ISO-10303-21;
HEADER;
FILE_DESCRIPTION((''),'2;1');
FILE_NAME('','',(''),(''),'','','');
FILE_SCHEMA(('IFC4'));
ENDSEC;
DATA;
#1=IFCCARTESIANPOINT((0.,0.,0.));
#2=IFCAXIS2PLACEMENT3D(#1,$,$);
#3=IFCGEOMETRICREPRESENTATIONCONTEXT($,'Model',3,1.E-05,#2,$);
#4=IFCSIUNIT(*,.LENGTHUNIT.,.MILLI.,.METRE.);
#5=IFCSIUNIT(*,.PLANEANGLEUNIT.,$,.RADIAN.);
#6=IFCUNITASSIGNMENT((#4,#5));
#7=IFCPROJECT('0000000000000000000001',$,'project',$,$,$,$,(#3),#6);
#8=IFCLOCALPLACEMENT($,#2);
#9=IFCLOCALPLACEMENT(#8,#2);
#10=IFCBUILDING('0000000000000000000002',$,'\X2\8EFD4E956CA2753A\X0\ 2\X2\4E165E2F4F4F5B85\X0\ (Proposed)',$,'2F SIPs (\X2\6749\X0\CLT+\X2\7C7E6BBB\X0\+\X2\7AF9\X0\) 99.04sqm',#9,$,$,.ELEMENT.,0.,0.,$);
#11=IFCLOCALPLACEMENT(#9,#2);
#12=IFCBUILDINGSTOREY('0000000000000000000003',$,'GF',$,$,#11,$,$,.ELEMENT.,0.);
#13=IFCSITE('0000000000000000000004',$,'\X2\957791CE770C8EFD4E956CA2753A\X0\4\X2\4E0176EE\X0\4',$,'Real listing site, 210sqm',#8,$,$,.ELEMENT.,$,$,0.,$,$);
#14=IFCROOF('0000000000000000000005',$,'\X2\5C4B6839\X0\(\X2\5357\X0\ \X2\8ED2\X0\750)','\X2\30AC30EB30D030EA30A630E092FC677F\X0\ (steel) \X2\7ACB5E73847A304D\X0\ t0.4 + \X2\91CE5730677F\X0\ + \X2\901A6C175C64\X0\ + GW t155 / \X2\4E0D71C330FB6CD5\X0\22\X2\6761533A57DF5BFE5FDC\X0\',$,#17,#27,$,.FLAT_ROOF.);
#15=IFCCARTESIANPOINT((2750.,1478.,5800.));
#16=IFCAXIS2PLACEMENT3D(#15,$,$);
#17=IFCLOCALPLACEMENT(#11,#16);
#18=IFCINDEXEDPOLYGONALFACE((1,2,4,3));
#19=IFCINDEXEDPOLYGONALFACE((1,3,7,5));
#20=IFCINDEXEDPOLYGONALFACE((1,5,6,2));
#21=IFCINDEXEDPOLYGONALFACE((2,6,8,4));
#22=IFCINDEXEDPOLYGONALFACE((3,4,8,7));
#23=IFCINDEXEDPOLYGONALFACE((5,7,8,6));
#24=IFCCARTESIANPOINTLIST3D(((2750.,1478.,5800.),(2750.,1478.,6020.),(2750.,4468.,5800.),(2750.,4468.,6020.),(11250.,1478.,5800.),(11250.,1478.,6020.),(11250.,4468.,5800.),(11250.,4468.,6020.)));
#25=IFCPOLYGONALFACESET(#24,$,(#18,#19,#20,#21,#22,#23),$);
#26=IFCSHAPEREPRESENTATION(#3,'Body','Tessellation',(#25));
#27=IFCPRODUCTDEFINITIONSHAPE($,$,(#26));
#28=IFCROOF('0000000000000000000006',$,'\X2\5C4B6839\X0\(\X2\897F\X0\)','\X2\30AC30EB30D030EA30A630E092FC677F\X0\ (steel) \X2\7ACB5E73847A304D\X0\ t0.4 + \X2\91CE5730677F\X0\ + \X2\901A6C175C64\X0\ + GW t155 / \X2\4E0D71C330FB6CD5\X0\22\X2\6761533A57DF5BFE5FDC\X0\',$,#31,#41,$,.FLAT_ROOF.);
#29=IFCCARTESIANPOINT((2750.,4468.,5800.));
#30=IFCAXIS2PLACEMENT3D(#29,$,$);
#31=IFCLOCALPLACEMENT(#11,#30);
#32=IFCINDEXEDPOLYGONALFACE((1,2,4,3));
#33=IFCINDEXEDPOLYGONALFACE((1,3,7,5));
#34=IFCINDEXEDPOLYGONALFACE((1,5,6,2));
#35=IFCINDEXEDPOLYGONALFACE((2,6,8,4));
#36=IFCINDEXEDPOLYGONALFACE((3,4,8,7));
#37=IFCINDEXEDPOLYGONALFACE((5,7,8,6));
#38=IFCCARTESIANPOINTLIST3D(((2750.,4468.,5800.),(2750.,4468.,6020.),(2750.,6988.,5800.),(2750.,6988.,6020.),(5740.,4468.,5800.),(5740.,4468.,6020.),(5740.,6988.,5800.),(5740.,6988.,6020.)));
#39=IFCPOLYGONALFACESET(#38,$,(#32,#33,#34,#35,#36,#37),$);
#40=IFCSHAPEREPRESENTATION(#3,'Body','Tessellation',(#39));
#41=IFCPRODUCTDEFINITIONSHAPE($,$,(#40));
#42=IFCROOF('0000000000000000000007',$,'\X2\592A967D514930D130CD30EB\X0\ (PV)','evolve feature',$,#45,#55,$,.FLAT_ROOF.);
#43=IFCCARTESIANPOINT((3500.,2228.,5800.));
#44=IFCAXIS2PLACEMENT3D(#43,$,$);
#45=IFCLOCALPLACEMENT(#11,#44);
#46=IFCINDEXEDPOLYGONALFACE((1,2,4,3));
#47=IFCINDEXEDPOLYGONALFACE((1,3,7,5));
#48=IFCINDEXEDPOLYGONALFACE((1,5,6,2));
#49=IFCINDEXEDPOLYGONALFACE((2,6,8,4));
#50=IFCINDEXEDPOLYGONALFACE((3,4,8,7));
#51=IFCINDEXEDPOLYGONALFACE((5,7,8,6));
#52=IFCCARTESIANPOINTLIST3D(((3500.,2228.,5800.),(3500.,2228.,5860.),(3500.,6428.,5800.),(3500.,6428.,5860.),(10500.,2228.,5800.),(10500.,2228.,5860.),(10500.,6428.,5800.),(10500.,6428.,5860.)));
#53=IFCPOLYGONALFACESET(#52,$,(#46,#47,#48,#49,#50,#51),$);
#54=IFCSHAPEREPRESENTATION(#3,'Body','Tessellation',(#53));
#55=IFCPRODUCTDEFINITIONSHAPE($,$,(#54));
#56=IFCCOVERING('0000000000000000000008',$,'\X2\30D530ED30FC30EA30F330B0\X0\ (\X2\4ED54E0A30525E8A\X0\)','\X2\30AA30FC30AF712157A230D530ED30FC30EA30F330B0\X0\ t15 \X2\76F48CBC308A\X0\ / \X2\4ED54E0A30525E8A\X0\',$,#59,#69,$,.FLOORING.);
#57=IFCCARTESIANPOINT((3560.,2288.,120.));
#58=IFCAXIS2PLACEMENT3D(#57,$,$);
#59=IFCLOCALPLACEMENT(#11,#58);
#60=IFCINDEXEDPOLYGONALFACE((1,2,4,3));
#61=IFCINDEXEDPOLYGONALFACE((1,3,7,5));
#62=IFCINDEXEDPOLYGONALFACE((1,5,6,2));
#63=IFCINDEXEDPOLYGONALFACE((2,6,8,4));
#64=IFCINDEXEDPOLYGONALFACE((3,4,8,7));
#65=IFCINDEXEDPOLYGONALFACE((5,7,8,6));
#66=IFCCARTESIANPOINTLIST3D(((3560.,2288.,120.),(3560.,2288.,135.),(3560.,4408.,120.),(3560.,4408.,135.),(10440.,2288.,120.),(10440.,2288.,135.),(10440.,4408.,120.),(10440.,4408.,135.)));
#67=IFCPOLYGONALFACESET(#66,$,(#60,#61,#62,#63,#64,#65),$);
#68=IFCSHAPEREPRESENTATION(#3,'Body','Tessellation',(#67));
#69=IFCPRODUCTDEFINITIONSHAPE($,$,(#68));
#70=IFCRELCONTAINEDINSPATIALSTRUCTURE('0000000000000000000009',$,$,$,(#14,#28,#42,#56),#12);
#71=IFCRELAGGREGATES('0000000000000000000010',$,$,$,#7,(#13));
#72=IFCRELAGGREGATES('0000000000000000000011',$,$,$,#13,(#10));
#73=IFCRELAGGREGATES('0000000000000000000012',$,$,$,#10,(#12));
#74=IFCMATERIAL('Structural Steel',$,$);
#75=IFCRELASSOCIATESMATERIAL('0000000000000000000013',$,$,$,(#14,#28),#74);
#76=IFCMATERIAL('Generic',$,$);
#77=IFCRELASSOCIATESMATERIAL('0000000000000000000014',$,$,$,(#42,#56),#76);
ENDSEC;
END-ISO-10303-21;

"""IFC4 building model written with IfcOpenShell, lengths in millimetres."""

from ifc_helpers import new_model, si_unit, frame, frame_2d, origin, place, context, project, spatial, rectangle, extrude, material, element, save


model = new_model("IFC4")

# Units and contexts
model_context = context("Model", 3, precision=1e-05, world=origin())
ifc_project = project(units=[si_unit("LENGTHUNIT", "METRE", prefix="MILLI"), si_unit("PLANEANGLEUNIT", "RADIAN")], contexts=[model_context])

# Site, building, storey
site_placement = place(None, origin())
site = spatial("IfcSite", under=ifc_project, at=site_placement, Name="長野県軽井沢町4丁目4", ObjectType="Real listing site, 210sqm", CompositionType="ELEMENT", RefElevation=0.0)
building_placement = place(site_placement, origin())
building = spatial("IfcBuilding", under=site, at=building_placement, Name="軽井沢町 2世帯住宅 (Proposed)", ObjectType="2F SIPs (杉CLT+籾殻+竹) 99.04sqm", CompositionType="ELEMENT", ElevationOfRefHeight=0.0, ElevationOfTerrain=0.0)
storey_placement = place(building_placement, origin())
storey = spatial("IfcBuildingStorey", under=building, at=storey_placement, Name="GF", CompositionType="ELEMENT", Elevation=0.0)

# Shared definitions
ifc_material_1 = material(Name="Generic")

# Roofs
ifc_material_2 = material(Name="Structural Steel")
roof_1_placement = place(storey_placement, frame((2750.0, 1478.0, 5800.0)))
element("IfcRoof", 1, at=roof_1_placement, inside=storey, material=ifc_material_2, Name="屋根(南 軒750)", Description="ガルバリウム鋼板 (steel) 立平葺き t0.4 + 野地板 + 通気層 + GW t155 / 不燃・法22条区域対応", PredefinedType="FLAT_ROOF", context=model_context, shape_type="SweptSolid", body=[
    extrude(rectangle(XDim=8500.0, YDim=2990.0, at=frame_2d((4250.0, 1495.0))), frame((2750.0, 1478.0, 5800.0)), (0.0, 0.0, 1.0), 220.0),
])
roof_2_placement = place(storey_placement, frame((2750.0, 4468.0, 5800.0)))
element("IfcRoof", 2, at=roof_2_placement, inside=storey, material=ifc_material_2, Name="屋根(西)", Description="ガルバリウム鋼板 (steel) 立平葺き t0.4 + 野地板 + 通気層 + GW t155 / 不燃・法22条区域対応", PredefinedType="FLAT_ROOF", context=model_context, shape_type="SweptSolid", body=[
    extrude(rectangle(XDim=2990.0, YDim=2520.0, at=frame_2d((1495.0, 1260.0))), frame((2750.0, 4468.0, 5800.0)), (0.0, 0.0, 1.0), 220.0),
])
roof_3_placement = place(storey_placement, frame((3500.0, 2228.0, 5800.0)))
element("IfcRoof", 3, at=roof_3_placement, inside=storey, material=ifc_material_1, Name="太陽光パネル (PV)", Description="evolve feature", PredefinedType="FLAT_ROOF", context=model_context, shape_type="SweptSolid", body=[
    extrude(rectangle(XDim=7000.0, YDim=4200.0, at=frame_2d((3500.0, 2100.0))), frame((3500.0, 2228.0, 5800.0)), (0.0, 0.0, 1.0), 60.0),
])

# Covering
covering_placement = place(storey_placement, frame((3560.0, 2288.0, 120.0)))
element("IfcCovering", 4, at=covering_placement, inside=storey, material=ifc_material_1, Name="フローリング (仕上げ床)", Description="オーク無垢フローリング t15 直貼り / 仕上げ床", PredefinedType="FLOORING", context=model_context, shape_type="SweptSolid", body=[
    extrude(rectangle(XDim=6880.0, YDim=2120.0, at=frame_2d((3440.0, 1060.0))), frame((3560.0, 2288.0, 120.0)), (0.0, 0.0, 1.0), 15.0),
])

save(model, "model.ifc")
